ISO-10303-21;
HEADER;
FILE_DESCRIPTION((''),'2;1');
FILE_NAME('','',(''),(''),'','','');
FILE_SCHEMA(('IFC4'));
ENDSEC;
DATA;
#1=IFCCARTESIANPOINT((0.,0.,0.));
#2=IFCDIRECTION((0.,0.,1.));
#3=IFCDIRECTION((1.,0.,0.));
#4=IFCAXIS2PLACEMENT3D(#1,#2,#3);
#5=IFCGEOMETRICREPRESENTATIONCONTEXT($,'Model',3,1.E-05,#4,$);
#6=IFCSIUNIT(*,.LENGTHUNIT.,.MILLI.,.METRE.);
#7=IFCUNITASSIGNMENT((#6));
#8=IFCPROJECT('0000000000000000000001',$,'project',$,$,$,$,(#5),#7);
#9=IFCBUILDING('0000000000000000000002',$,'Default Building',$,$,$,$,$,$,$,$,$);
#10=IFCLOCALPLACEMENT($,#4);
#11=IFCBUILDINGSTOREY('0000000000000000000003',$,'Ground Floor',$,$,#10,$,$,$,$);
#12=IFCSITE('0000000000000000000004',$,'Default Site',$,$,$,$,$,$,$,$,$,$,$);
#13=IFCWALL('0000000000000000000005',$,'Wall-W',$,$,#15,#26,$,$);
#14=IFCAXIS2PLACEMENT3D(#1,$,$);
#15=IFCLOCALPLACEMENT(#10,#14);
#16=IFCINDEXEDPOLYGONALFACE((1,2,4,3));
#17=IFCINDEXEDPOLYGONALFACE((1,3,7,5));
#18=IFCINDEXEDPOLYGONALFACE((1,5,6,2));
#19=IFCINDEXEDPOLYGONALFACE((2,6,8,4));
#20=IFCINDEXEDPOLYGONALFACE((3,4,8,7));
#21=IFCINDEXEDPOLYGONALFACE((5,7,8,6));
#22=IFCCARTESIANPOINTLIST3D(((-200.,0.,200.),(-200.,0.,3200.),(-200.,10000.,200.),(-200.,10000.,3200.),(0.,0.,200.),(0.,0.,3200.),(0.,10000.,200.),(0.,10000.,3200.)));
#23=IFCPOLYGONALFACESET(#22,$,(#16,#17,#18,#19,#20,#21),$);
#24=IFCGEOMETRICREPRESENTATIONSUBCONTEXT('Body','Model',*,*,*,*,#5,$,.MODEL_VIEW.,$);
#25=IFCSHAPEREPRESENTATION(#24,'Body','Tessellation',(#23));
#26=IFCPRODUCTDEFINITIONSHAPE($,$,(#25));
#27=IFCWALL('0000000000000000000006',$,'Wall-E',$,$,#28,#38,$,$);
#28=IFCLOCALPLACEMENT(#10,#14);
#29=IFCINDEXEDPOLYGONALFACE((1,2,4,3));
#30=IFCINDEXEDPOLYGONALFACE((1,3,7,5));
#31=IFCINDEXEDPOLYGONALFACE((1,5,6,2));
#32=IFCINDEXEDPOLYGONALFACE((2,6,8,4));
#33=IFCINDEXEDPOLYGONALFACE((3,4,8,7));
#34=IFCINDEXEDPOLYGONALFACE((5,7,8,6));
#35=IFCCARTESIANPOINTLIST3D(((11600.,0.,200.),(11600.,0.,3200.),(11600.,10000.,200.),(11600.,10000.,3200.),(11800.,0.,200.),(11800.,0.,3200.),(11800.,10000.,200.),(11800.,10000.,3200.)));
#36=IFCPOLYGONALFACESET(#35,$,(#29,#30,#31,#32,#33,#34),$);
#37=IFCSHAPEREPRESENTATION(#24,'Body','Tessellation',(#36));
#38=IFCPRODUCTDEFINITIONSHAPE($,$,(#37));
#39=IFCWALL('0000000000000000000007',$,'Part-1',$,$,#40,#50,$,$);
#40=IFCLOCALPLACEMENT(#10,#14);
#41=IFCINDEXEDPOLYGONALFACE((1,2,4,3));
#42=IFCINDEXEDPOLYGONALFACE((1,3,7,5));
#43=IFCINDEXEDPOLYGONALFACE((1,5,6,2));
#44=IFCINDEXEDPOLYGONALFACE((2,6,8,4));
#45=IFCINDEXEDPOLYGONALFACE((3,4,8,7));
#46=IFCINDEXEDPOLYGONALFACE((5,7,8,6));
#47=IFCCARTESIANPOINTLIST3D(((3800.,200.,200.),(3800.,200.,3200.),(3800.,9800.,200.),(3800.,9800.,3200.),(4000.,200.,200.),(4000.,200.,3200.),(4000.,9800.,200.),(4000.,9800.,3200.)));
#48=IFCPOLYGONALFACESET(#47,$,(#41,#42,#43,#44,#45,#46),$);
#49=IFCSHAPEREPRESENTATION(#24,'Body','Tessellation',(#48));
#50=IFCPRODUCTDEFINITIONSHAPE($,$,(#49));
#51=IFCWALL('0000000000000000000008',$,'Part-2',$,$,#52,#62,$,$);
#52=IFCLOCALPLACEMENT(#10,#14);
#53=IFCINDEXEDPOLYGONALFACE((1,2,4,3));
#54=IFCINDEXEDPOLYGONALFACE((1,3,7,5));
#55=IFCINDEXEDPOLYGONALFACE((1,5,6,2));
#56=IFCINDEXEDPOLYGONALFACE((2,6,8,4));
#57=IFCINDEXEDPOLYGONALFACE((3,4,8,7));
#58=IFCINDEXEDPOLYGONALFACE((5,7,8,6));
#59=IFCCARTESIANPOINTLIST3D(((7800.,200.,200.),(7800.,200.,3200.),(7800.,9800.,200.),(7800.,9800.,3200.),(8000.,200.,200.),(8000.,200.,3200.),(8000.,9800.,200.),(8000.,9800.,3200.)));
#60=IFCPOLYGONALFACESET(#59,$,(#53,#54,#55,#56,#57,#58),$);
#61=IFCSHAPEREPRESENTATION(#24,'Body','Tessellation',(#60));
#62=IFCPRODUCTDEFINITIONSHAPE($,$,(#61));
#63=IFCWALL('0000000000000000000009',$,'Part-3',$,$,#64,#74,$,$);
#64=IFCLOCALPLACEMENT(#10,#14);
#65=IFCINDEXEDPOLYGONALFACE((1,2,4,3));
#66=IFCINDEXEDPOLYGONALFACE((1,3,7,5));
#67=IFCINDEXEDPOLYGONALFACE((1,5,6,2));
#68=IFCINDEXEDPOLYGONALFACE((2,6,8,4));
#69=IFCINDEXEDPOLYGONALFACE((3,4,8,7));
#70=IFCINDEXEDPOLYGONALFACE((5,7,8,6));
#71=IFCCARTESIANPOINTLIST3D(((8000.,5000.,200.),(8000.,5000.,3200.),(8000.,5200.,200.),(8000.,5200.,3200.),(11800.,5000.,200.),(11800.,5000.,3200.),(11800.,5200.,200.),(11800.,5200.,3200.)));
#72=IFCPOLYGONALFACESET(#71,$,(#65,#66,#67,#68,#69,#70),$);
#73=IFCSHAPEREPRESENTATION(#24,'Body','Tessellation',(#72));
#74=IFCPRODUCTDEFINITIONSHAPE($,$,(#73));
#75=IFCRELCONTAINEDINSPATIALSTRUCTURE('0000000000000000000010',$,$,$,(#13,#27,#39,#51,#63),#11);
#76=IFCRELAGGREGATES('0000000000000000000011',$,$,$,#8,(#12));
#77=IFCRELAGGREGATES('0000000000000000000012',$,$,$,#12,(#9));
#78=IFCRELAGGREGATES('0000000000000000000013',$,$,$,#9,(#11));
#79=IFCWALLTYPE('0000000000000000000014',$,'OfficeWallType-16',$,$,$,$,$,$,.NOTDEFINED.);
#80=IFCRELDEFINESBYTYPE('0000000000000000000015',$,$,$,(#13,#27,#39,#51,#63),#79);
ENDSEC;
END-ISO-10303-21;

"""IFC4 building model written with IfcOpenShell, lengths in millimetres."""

from ifc_helpers import new_model, si_unit, frame, origin_with_axes, place, context, subcontext, project, spatial, indexed_curve, outline, extrude, type_object, element, save


model = new_model("IFC4")

# Units and contexts
model_context = context("Model", 3, precision=1e-05, world=origin_with_axes())
body_context = subcontext(model_context, "Body", "Model", "MODEL_VIEW")
ifc_project = project(units=[si_unit("LENGTHUNIT", "METRE", prefix="MILLI")], contexts=[model_context])

# Site, building, storey
site = spatial("IfcSite", under=ifc_project, Name="Default Site")
building = spatial("IfcBuilding", under=site, Name="Default Building")
storey_placement = place(None, origin_with_axes())
storey = spatial("IfcBuildingStorey", under=building, at=storey_placement, Name="Ground Floor")

# Shared definitions
wall_type = type_object("IfcWallType", Name="OfficeWallType-16", PredefinedType="NOTDEFINED")

# Walls
wall_1_placement = place(storey_placement, frame((0.0, 0.0, 200.0), z_axis=(0.0, 0.0, 1.0), x_axis=(1.0, 0.0, 0.0)))
element("IfcWall", 1, at=wall_1_placement, inside=storey, type_object=wall_type, Name="Wall-W", context=body_context, shape_type="SweptSolid", body=[
    extrude(outline(indexed_curve([(0.0, 0.0), (0.0, 10000.0), (-200.0, 10000.0), (-200.0, 0.0), (0.0, 0.0)])), None, (0.0, 0.0, 1.0), 3000.0),
])
wall_2_placement = place(storey_placement, frame((0.0, 0.0, 200.0), z_axis=(0.0, 0.0, 1.0), x_axis=(1.0, 0.0, 0.0)))
element("IfcWall", 2, at=wall_2_placement, inside=storey, type_object=wall_type, Name="Wall-E", context=body_context, shape_type="SweptSolid", body=[
    extrude(outline(indexed_curve([(11800.0, 0.0), (11800.0, 10000.0), (11600.0, 10000.0), (11600.0, 0.0), (11800.0, 0.0)])), None, (0.0, 0.0, 1.0), 3000.0),
])
wall_3_placement = place(storey_placement, frame((0.0, 0.0, 200.0), z_axis=(0.0, 0.0, 1.0), x_axis=(1.0, 0.0, 0.0)))
element("IfcWall", 3, at=wall_3_placement, inside=storey, type_object=wall_type, Name="Part-1", context=body_context, shape_type="SweptSolid", body=[
    extrude(outline(indexed_curve([(4000.0, 200.0), (4000.0, 9800.0), (3800.0, 9800.0), (3800.0, 200.0), (4000.0, 200.0)])), None, (0.0, 0.0, 1.0), 3000.0),
])
wall_4_placement = place(storey_placement, frame((0.0, 0.0, 200.0), z_axis=(0.0, 0.0, 1.0), x_axis=(1.0, 0.0, 0.0)))
element("IfcWall", 4, at=wall_4_placement, inside=storey, type_object=wall_type, Name="Part-2", context=body_context, shape_type="SweptSolid", body=[
    extrude(outline(indexed_curve([(8000.0, 200.0), (8000.0, 9800.0), (7800.0, 9800.0), (7800.0, 200.0), (8000.0, 200.0)])), None, (0.0, 0.0, 1.0), 3000.0),
])
wall_5_placement = place(storey_placement, frame((0.0, 0.0, 200.0), z_axis=(0.0, 0.0, 1.0), x_axis=(1.0, 0.0, 0.0)))
element("IfcWall", 5, at=wall_5_placement, inside=storey, type_object=wall_type, Name="Part-3", context=body_context, shape_type="SweptSolid", body=[
    extrude(outline(indexed_curve([(8000.0, 5000.0), (11800.0, 5000.0), (11800.0, 5200.0), (8000.0, 5200.0), (8000.0, 5000.0)])), None, (0.0, 0.0, 1.0), 3000.0),
])

save(model, "model.ifc")
